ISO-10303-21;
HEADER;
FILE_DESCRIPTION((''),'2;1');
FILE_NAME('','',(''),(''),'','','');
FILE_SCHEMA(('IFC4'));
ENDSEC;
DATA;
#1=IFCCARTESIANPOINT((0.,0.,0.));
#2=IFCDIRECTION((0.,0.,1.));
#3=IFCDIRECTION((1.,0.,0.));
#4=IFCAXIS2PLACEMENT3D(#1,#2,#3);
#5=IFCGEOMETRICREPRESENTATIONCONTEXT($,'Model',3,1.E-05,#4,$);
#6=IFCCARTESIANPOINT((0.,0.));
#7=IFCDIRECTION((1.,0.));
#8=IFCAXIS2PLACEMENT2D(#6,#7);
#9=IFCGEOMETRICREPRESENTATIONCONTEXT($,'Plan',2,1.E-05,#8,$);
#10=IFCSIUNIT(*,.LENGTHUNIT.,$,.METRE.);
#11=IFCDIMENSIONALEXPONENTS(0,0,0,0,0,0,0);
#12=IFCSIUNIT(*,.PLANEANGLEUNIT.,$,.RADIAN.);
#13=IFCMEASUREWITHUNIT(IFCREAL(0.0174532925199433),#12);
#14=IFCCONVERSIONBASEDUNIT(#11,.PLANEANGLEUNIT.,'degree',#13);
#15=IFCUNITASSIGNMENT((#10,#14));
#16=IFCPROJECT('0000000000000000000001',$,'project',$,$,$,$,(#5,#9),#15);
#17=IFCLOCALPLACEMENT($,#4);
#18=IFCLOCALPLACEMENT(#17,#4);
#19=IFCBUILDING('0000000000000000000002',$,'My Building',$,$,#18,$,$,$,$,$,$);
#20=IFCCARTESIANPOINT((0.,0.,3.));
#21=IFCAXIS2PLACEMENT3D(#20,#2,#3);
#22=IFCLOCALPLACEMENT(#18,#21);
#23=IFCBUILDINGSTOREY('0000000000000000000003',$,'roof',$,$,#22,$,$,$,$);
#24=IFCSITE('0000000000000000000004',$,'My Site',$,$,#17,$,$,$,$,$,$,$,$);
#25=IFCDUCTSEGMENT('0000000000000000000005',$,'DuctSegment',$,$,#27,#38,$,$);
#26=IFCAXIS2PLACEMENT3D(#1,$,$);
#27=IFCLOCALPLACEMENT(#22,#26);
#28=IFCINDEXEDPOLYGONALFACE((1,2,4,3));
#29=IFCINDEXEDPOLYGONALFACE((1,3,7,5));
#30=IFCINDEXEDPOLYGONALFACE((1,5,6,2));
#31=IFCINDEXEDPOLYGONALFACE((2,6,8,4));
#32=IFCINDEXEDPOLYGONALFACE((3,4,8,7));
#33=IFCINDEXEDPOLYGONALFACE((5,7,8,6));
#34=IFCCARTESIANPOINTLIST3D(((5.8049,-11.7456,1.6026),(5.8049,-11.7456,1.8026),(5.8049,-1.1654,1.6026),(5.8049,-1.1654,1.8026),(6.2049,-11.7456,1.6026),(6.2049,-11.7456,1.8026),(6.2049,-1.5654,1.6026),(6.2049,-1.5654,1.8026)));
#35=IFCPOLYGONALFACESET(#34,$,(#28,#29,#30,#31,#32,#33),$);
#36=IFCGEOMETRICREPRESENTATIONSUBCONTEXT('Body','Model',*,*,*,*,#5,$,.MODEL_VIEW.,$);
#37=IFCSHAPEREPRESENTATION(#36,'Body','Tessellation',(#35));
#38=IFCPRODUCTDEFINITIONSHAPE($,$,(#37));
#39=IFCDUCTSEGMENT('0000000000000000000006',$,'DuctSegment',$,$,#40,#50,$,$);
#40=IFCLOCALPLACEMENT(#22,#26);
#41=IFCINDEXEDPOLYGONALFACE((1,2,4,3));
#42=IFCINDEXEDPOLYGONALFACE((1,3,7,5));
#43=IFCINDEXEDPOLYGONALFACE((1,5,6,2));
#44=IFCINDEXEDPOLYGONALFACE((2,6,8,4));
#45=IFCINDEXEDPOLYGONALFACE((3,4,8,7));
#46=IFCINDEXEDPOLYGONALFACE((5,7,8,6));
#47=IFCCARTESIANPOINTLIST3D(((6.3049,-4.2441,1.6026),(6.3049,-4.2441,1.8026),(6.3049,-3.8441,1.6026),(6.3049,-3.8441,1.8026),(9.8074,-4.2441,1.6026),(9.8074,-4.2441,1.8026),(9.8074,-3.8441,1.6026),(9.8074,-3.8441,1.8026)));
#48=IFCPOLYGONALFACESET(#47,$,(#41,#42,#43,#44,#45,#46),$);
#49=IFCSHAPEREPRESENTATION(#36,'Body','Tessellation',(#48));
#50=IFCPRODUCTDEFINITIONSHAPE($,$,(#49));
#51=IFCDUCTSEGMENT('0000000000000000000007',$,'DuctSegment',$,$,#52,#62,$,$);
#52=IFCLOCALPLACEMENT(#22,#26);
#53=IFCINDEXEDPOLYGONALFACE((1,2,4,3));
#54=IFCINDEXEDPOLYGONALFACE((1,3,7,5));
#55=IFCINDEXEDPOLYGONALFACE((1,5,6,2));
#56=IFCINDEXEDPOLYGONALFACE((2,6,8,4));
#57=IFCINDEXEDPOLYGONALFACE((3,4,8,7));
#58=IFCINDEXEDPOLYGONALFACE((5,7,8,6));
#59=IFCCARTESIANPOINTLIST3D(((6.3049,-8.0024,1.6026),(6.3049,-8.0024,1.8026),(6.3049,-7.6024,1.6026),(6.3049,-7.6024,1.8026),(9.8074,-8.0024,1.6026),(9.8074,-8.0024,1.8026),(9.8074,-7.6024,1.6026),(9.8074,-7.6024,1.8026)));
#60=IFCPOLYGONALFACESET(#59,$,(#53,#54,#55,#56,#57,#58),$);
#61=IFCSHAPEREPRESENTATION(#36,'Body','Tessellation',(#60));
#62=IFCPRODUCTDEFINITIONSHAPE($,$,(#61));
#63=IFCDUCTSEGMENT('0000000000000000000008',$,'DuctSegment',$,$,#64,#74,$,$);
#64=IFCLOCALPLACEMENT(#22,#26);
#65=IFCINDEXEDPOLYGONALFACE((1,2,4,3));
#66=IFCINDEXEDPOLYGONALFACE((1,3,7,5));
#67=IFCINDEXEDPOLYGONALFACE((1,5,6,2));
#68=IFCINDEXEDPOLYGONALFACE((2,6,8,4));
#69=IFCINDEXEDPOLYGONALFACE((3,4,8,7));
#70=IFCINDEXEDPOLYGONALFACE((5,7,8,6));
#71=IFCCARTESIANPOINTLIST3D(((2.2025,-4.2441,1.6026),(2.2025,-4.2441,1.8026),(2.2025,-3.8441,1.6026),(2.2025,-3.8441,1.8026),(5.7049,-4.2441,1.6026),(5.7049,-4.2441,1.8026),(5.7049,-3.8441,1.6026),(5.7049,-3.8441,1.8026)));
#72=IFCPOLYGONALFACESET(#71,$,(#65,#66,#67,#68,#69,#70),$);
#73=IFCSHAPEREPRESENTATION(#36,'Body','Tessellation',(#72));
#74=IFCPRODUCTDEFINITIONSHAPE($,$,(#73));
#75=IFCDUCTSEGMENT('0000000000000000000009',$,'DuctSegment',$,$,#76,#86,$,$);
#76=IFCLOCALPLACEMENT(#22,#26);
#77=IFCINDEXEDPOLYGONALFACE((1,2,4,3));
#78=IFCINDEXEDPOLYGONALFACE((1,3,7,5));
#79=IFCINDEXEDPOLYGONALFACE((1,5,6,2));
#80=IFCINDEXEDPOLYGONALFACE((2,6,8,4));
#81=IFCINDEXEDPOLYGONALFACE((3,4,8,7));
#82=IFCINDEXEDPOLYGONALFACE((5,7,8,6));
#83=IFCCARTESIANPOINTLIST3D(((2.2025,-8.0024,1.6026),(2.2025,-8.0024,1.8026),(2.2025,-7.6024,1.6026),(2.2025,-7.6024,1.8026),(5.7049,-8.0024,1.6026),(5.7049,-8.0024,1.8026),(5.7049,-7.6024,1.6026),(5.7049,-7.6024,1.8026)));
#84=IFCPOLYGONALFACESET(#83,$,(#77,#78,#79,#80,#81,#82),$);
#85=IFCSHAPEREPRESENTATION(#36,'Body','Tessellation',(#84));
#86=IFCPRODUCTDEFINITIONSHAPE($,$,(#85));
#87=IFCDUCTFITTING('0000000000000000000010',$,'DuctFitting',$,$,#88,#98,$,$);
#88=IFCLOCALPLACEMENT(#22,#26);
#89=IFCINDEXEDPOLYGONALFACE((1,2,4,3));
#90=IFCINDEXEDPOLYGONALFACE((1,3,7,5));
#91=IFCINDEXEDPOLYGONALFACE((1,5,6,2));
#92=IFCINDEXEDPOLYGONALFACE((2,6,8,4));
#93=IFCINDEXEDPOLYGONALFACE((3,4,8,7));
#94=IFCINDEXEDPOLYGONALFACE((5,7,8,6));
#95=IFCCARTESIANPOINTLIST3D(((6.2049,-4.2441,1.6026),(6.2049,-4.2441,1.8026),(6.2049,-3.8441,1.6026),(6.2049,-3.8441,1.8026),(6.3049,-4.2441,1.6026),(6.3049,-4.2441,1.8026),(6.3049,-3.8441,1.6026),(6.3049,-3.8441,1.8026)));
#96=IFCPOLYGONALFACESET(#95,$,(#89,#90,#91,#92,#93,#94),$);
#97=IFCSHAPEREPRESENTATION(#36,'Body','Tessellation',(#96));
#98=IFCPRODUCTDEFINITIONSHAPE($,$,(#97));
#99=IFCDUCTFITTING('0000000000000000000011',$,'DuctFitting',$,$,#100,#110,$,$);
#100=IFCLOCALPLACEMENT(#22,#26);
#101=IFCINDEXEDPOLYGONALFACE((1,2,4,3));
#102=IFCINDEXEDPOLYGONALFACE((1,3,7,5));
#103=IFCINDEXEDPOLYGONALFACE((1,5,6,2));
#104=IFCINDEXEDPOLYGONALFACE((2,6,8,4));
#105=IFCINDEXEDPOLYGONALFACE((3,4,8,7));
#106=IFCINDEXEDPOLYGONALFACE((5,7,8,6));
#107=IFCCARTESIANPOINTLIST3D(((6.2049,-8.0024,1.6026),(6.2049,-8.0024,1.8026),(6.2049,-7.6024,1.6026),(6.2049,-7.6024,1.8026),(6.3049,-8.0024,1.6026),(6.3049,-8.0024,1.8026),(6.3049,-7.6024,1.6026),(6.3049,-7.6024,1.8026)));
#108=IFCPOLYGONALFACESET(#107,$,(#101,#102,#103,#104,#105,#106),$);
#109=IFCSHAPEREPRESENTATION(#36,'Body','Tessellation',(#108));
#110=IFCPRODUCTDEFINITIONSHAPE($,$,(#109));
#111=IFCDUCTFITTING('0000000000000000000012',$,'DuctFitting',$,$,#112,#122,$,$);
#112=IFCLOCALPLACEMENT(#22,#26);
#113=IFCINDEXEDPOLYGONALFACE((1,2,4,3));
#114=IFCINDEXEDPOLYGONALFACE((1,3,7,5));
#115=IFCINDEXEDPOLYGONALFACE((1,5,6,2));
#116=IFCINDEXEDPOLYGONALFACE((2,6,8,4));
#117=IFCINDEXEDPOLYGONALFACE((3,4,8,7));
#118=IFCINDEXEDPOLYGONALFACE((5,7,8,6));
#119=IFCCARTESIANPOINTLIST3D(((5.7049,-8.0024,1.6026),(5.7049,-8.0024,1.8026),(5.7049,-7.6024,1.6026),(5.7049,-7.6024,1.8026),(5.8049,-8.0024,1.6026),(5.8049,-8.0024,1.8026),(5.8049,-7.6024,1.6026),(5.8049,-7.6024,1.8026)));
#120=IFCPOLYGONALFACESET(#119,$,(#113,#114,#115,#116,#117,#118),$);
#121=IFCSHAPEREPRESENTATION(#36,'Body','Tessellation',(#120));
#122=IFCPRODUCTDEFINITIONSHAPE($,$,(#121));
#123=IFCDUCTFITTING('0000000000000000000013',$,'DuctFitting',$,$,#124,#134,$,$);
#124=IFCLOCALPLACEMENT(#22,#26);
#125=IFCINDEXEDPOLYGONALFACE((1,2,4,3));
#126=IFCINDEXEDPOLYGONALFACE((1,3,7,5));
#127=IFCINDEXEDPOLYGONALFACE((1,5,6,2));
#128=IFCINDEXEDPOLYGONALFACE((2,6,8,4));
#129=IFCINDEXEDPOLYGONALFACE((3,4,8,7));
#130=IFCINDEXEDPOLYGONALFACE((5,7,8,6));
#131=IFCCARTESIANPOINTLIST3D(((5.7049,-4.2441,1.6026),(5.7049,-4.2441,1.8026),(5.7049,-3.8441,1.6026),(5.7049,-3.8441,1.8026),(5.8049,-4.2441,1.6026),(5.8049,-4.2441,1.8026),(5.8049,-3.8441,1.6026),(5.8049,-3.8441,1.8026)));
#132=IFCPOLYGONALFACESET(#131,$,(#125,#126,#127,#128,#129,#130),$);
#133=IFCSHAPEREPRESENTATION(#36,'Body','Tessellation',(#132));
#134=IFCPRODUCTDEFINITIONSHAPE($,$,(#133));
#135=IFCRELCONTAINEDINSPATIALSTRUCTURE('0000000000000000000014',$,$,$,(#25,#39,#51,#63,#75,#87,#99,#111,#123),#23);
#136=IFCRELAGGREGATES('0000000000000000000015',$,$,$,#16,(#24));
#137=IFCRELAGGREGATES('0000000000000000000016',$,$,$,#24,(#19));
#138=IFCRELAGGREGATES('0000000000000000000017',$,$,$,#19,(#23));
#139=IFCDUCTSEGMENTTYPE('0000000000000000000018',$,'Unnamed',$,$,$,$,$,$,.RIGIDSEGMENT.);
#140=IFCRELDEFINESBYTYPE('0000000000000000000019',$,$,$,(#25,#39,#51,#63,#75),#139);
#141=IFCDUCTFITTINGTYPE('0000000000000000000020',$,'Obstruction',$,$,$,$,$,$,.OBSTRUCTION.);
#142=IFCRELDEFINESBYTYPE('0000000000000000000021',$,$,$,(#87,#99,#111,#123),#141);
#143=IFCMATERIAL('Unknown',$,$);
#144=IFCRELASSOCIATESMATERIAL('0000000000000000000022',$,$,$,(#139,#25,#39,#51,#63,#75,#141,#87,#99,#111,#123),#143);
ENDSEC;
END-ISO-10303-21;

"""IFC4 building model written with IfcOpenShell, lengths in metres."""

from ifc_helpers import new_model, entity, si_unit, converted_unit, frame, origin_with_axes, origin_2d_with_axis, place, context, subcontext, project, spatial, rectangle, extrude, clip, halfspace, material, material_profile, profile_set, profile_usage, type_object, element, save


model = new_model("IFC4")

# Units and contexts
model_context = context("Model", 3, precision=1e-05, world=origin_with_axes())
plan_context = context("Plan", 2, precision=1e-05, world=origin_2d_with_axis())
body_context = subcontext(model_context, "Body", "Model", "MODEL_VIEW")
ifc_project = project(units=[si_unit("LENGTHUNIT", "METRE"), converted_unit("PLANEANGLEUNIT", "degree", entity("IfcReal", 0.0174532925199433), si_unit("PLANEANGLEUNIT", "RADIAN"), dimensions=[0, 0, 0, 0, 0, 0, 0])], contexts=[model_context, plan_context])

# Site, building, storey
site_placement = place(None, origin_with_axes())
site = spatial("IfcSite", under=ifc_project, at=site_placement, Name="My Site")
building_placement = place(site_placement, origin_with_axes())
building = spatial("IfcBuilding", under=site, at=building_placement, Name="My Building")
storey_placement = place(building_placement, frame((0.0, 0.0, 3.0), z_axis=(0.0, 0.0, 1.0), x_axis=(1.0, 0.0, 0.0)))
storey = spatial("IfcBuildingStorey", under=building, at=storey_placement, Name="roof")

# Shared definitions
ifc_material = material(Name="Unknown")

# Duct segments
ifc_material_profile_1 = material_profile(ifc_material, rectangle(XDim=0.4, YDim=0.2))
ifc_profile_set_1 = profile_set([ifc_material_profile_1])
duct_segment_type = type_object("IfcDuctSegmentType", Name="Unnamed", PredefinedType="RIGIDSEGMENT", material=ifc_profile_set_1)
ifc_profile_usage_1 = profile_usage(ifc_profile_set_1, cardinal=5)
duct_segment_1_placement = place(storey_placement, frame((6.0049, -1.1654, 1.7026), z_axis=(0.0, -1.0, 0.0), x_axis=(1.0, 0.0, 0.0)))
element("IfcDuctSegment", 1, at=duct_segment_1_placement, inside=storey, type_object=duct_segment_type, material=ifc_profile_usage_1, Name="DuctSegment", context=body_context, shape_type="Clipping", body=[
    clip(extrude(rectangle(XDim=0.4, YDim=0.2), origin_with_axes(), (0.0, 0.0, 1.0), 10.5802), halfspace(frame((-0.2, -1.5, 0.0), z_axis=(0.707107, 0.0, -0.707107), x_axis=(0.0, -1.0, 0.0)), False)),
])
ifc_profile_usage_2 = profile_usage(ifc_profile_set_1, cardinal=5)
duct_segment_2_placement = place(storey_placement, frame((6.3049, -4.0441, 1.7026), z_axis=(1.0, 0.0, 0.0), x_axis=(0.0, 1.0, 0.0)))
element("IfcDuctSegment", 2, at=duct_segment_2_placement, inside=storey, type_object=duct_segment_type, material=ifc_profile_usage_2, Name="DuctSegment", context=body_context, shape_type="SweptSolid", body=[
    extrude(rectangle(XDim=0.4, YDim=0.2), origin_with_axes(), (0.0, 0.0, 1.0), 3.5025),
])
ifc_profile_usage_3 = profile_usage(ifc_profile_set_1, cardinal=5)
duct_segment_3_placement = place(storey_placement, frame((6.3049, -7.8024, 1.7026), z_axis=(1.0, 0.0, 0.0), x_axis=(0.0, 1.0, 0.0)))
element("IfcDuctSegment", 3, at=duct_segment_3_placement, inside=storey, type_object=duct_segment_type, material=ifc_profile_usage_3, Name="DuctSegment", context=body_context, shape_type="SweptSolid", body=[
    extrude(rectangle(XDim=0.4, YDim=0.2), origin_with_axes(), (0.0, 0.0, 1.0), 3.5025),
])
ifc_profile_usage_4 = profile_usage(ifc_profile_set_1, cardinal=5)
duct_segment_4_placement = place(storey_placement, frame((5.7049, -4.0441, 1.7026), z_axis=(-1.0, 0.0, 0.0), x_axis=(0.0, 1.0, 0.0)))
element("IfcDuctSegment", 4, at=duct_segment_4_placement, inside=storey, type_object=duct_segment_type, material=ifc_profile_usage_4, Name="DuctSegment", context=body_context, shape_type="SweptSolid", body=[
    extrude(rectangle(XDim=0.4, YDim=0.2), origin_with_axes(), (0.0, 0.0, 1.0), 3.5025),
])
ifc_profile_usage_5 = profile_usage(ifc_profile_set_1, cardinal=5)
duct_segment_5_placement = place(storey_placement, frame((5.7049, -7.8024, 1.7026), z_axis=(-1.0, 0.0, 0.0), x_axis=(0.0, 1.0, 0.0)))
element("IfcDuctSegment", 5, at=duct_segment_5_placement, inside=storey, type_object=duct_segment_type, material=ifc_profile_usage_5, Name="DuctSegment", context=body_context, shape_type="SweptSolid", body=[
    extrude(rectangle(XDim=0.4, YDim=0.2), origin_with_axes(), (0.0, 0.0, 1.0), 3.5025),
])

# Duct fittings
ifc_material_profile_2 = material_profile(ifc_material, rectangle(XDim=0.4, YDim=0.2))
ifc_profile_set_2 = profile_set([ifc_material_profile_2])
ifc_profile_usage_6 = profile_usage(ifc_profile_set_2, cardinal=5)
duct_fitting_type = type_object("IfcDuctFittingType", Name="Obstruction", PredefinedType="OBSTRUCTION", material=ifc_profile_set_2)
duct_fitting_1_placement = place(storey_placement, frame((6.2049, -4.0441, 1.7026), z_axis=(1.0, 0.0, 0.0), x_axis=(0.0, 1.0, 0.0)))
element("IfcDuctFitting", 6, at=duct_fitting_1_placement, inside=storey, type_object=duct_fitting_type, material=ifc_profile_usage_6, Name="DuctFitting", context=body_context, shape_type="SweptSolid", body=[
    extrude(rectangle(XDim=0.4, YDim=0.2), origin_with_axes(), (0.0, 0.0, 1.0), 0.1),
])
ifc_profile_usage_7 = profile_usage(ifc_profile_set_2, cardinal=5)
duct_fitting_2_placement = place(storey_placement, frame((6.2049, -7.8024, 1.7026), z_axis=(1.0, 0.0, 0.0), x_axis=(0.0, 1.0, 0.0)))
element("IfcDuctFitting", 7, at=duct_fitting_2_placement, inside=storey, type_object=duct_fitting_type, material=ifc_profile_usage_7, Name="DuctFitting", context=body_context, shape_type="SweptSolid", body=[
    extrude(rectangle(XDim=0.4, YDim=0.2), origin_with_axes(), (0.0, 0.0, 1.0), 0.1),
])
ifc_profile_usage_8 = profile_usage(ifc_profile_set_2, cardinal=5)
duct_fitting_3_placement = place(storey_placement, frame((5.8049, -7.8024, 1.7026), z_axis=(-1.0, 0.0, 0.0), x_axis=(0.0, 1.0, 0.0)))
element("IfcDuctFitting", 8, at=duct_fitting_3_placement, inside=storey, type_object=duct_fitting_type, material=ifc_profile_usage_8, Name="DuctFitting", context=body_context, shape_type="SweptSolid", body=[
    extrude(rectangle(XDim=0.4, YDim=0.2), origin_with_axes(), (0.0, 0.0, 1.0), 0.1),
])
ifc_profile_usage_9 = profile_usage(ifc_profile_set_2, cardinal=5)
duct_fitting_4_placement = place(storey_placement, frame((5.8049, -4.0441, 1.7026), z_axis=(-1.0, 0.0, 0.0), x_axis=(0.0, 1.0, 0.0)))
element("IfcDuctFitting", 9, at=duct_fitting_4_placement, inside=storey, type_object=duct_fitting_type, material=ifc_profile_usage_9, Name="DuctFitting", context=body_context, shape_type="SweptSolid", body=[
    extrude(rectangle(XDim=0.4, YDim=0.2), origin_with_axes(), (0.0, 0.0, 1.0), 0.1),
])

save(model, "model.ifc")
